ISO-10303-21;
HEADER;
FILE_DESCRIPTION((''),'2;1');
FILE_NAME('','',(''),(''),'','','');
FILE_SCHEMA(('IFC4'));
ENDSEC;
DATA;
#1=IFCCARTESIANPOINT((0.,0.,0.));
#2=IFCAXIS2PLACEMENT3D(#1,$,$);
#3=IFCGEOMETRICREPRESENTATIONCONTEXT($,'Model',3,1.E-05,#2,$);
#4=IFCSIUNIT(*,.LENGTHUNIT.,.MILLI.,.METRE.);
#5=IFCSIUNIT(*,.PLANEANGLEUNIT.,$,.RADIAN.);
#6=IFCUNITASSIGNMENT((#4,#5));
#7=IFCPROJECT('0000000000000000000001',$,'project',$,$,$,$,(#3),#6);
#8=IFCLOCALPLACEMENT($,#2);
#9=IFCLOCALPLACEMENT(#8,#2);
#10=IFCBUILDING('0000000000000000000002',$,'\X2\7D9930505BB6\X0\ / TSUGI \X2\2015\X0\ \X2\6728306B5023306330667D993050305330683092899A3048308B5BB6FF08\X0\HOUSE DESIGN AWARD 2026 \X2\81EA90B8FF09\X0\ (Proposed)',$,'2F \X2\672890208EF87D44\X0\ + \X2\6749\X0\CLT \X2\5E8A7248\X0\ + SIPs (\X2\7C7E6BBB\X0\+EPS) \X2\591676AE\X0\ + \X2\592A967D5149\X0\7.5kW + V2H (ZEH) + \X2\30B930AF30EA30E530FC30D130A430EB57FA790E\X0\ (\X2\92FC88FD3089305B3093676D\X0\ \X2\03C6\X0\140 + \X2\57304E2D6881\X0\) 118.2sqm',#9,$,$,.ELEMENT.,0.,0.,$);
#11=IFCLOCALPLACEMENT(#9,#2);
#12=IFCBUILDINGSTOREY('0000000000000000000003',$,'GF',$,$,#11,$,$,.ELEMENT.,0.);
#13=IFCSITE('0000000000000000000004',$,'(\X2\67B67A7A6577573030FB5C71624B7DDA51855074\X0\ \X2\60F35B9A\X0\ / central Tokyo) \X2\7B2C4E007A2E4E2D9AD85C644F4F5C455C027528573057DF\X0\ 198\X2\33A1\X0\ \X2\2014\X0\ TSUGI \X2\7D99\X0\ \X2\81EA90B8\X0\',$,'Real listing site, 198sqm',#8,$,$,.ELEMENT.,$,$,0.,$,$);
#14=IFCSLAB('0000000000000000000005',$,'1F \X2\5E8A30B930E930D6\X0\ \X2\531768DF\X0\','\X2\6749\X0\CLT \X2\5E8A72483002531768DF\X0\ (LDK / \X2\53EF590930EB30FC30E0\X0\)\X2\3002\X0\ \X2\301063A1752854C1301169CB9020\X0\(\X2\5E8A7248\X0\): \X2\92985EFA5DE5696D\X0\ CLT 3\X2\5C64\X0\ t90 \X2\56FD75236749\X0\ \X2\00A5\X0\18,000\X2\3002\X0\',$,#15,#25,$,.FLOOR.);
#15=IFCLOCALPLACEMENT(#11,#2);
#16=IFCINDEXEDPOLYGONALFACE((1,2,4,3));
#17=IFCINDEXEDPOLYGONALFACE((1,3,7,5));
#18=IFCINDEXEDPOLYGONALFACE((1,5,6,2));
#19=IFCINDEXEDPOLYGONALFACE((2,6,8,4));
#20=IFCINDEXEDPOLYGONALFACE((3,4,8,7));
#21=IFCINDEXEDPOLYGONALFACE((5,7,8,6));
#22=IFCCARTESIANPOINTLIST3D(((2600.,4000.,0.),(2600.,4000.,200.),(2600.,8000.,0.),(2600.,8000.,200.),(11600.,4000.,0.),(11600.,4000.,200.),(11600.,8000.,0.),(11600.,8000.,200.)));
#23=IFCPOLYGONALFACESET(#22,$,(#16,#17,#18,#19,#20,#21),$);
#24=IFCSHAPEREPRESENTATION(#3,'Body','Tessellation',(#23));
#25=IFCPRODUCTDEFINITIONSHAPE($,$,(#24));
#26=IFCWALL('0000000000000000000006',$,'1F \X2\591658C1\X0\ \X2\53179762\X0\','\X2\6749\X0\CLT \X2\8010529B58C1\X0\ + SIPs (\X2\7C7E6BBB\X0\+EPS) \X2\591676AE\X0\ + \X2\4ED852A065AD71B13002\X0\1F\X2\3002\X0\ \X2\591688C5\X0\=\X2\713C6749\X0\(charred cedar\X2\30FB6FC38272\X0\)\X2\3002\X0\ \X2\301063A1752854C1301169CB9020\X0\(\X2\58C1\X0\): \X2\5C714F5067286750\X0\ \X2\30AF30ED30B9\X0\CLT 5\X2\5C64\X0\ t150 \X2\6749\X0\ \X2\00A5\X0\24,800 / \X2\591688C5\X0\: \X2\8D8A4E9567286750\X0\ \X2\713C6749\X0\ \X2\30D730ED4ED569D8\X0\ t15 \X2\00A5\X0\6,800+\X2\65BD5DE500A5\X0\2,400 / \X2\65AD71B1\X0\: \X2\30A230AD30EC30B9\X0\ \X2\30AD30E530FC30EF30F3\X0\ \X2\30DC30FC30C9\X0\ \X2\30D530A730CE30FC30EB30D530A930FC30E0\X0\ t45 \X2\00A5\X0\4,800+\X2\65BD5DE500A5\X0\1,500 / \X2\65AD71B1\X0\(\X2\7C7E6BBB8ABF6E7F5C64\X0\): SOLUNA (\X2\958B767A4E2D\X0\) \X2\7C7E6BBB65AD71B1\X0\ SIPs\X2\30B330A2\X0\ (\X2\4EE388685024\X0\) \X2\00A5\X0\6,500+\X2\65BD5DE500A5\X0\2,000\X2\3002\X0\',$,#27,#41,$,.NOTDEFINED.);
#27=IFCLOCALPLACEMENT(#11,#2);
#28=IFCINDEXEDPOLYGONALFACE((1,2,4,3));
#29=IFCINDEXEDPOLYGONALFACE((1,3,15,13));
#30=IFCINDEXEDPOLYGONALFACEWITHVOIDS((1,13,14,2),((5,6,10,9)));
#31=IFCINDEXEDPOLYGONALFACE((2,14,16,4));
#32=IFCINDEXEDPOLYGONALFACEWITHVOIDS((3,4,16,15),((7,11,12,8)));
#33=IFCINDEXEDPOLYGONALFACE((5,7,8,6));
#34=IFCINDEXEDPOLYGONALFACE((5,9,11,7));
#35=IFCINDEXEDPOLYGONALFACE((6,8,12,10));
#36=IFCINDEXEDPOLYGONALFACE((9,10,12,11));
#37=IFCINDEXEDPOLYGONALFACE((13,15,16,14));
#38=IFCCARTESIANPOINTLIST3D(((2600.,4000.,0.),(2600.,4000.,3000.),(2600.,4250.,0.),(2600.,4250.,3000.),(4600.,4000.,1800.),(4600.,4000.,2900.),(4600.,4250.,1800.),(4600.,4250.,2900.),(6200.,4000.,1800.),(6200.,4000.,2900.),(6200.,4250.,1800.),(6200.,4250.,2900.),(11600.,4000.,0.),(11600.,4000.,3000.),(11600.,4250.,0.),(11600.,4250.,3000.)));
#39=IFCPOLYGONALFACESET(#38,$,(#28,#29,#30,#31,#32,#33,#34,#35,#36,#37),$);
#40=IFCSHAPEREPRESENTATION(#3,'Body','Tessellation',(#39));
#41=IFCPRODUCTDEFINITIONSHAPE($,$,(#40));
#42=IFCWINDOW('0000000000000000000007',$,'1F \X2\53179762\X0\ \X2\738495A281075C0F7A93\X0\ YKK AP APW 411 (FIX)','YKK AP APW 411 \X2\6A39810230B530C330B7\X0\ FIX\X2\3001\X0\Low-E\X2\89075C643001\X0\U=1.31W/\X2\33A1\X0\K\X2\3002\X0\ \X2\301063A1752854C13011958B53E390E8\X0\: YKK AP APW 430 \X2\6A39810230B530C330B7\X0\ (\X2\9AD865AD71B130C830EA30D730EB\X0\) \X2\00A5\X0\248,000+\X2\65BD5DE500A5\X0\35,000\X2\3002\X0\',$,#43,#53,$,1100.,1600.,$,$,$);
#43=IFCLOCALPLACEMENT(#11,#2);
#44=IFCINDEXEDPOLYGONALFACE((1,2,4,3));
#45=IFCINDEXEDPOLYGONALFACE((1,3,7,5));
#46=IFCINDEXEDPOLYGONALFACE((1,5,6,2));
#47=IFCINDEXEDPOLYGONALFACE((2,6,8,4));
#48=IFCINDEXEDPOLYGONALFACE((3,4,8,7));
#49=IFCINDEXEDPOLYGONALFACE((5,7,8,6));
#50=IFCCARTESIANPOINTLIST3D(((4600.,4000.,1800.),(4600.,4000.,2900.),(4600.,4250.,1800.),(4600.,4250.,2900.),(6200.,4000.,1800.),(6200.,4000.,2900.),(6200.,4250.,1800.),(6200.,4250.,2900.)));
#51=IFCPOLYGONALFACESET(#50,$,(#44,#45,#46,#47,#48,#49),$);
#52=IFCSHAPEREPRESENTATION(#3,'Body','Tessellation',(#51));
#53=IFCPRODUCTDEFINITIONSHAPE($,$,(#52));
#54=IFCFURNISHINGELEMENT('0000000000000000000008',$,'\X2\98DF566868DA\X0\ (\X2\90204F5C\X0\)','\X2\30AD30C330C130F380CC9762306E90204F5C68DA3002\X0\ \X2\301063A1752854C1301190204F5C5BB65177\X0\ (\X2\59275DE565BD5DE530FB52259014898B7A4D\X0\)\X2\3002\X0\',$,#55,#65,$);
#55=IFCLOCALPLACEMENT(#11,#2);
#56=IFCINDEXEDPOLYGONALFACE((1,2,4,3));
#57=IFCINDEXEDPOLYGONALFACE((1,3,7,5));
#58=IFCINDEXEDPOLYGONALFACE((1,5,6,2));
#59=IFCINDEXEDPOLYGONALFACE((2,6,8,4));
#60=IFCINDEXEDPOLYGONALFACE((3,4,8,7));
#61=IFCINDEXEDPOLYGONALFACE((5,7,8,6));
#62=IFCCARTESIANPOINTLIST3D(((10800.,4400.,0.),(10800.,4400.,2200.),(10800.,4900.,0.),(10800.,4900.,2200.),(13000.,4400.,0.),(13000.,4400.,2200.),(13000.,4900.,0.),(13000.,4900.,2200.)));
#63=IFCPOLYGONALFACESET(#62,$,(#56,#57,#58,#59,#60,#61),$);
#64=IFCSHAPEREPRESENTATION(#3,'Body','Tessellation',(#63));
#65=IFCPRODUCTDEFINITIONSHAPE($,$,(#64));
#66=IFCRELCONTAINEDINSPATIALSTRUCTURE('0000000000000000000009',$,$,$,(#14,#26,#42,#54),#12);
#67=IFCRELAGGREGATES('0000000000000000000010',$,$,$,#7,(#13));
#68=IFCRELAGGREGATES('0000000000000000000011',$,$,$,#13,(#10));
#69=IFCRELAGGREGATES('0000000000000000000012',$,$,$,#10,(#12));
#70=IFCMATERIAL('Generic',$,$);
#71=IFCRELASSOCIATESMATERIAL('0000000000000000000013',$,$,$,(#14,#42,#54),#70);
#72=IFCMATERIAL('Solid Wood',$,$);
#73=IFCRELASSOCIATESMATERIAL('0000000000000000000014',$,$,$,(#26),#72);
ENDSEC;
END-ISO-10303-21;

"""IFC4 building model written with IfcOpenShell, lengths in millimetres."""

from ifc_helpers import new_model, si_unit, frame, frame_2d, origin, place, context, project, spatial, rectangle, extrude, material, element, fill, save


model = new_model("IFC4")

# Units and contexts
model_context = context("Model", 3, precision=1e-05, world=origin())
ifc_project = project(units=[si_unit("LENGTHUNIT", "METRE", prefix="MILLI"), si_unit("PLANEANGLEUNIT", "RADIAN")], contexts=[model_context])

# Site, building, storey
site_placement = place(None, origin())
site = spatial("IfcSite", under=ifc_project, at=site_placement, Name="(架空敷地・山手線内側 想定 / central Tokyo) 第一種中高層住居専用地域 198㎡ — TSUGI 継 自邸", ObjectType="Real listing site, 198sqm", CompositionType="ELEMENT", RefElevation=0.0)
building_placement = place(site_placement, origin())
building = spatial("IfcBuilding", under=site, at=building_placement, Name="継ぐ家 / TSUGI ― 木に倣って継ぐことを覚える家（HOUSE DESIGN AWARD 2026 自邸） (Proposed)", ObjectType="2F 木造軸組 + 杉CLT 床版 + SIPs (籾殻+EPS) 外皮 + 太陽光7.5kW + V2H (ZEH) + スクリューパイル基礎 (鋼製らせん杭 φ140 + 地中梁) 118.2sqm", CompositionType="ELEMENT", ElevationOfRefHeight=0.0, ElevationOfTerrain=0.0)
storey_placement = place(building_placement, origin())
storey = spatial("IfcBuildingStorey", under=building, at=storey_placement, Name="GF", CompositionType="ELEMENT", Elevation=0.0)

# Shared definitions
ifc_material_1 = material(Name="Generic")

# Slab
slab_1_placement = place(storey_placement, frame((1300.0, 2000.0, 0.0)))
element("IfcSlab", 1, at=slab_1_placement, inside=storey, material=ifc_material_1, Name="1F 床スラブ 北棟", Description="杉CLT 床版。北棟 (LDK / 可変ルーム)。 【採用品】構造(床版): 銘建工業 CLT 3層 t90 国産杉 ¥18,000。", PredefinedType="FLOOR", context=model_context, shape_type="SweptSolid", body=[
    extrude(rectangle(XDim=9000.0, YDim=4000.0, at=frame_2d((4500.0, 2000.0))), frame((1300.0, 2000.0, 0.0)), (0.0, 0.0, 1.0), 200.0),
])

# Wall, opening, window
ifc_material_2 = material(Name="Solid Wood")
wall_1_placement = place(storey_placement, frame((1300.0, 2000.0, 0.0)))
wall_1 = element("IfcWall", 2, at=wall_1_placement, inside=storey, material=ifc_material_2, Name="1F 外壁 北面", Description="杉CLT 耐力壁 + SIPs (籾殻+EPS) 外皮 + 付加断熱。1F。 外装=焼杉(charred cedar・濃色)。 【採用品】構造(壁): 山佐木材 クロスCLT 5層 t150 杉 ¥24,800 / 外装: 越井木材 焼杉 プロ仕様 t15 ¥6,800+施工¥2,400 / 断熱: アキレス キューワン ボード フェノールフォーム t45 ¥4,800+施工¥1,500 / 断熱(籾殻調湿層): SOLUNA (開発中) 籾殻断熱 SIPsコア (代表値) ¥6,500+施工¥2,000。", PredefinedType="NOTDEFINED", context=model_context, shape_type="SweptSolid", body=[
    extrude(rectangle(XDim=9000.0, YDim=250.0, at=frame_2d((4500.0, 125.0))), frame((1300.0, 2000.0, 0.0)), (0.0, 0.0, 1.0), 3000.0),
])
opening_placement = place(storey_placement, frame((2300.0, 2000.0, 900.0)))
opening = element("IfcOpeningElement", 3, at=opening_placement, cuts=wall_1, PredefinedType="NOTDEFINED", context=model_context, shape_type="SweptSolid", body=[
    extrude(rectangle(XDim=1600.0, YDim=250.0, at=frame_2d((800.0, 125.0))), frame((2300.0, 2000.0, 900.0)), (0.0, 0.0, 1.0), 1100.0),
])
window_placement = place(storey_placement, frame((2300.0, 2000.0, 900.0)))
window = element("IfcWindow", 4, at=window_placement, inside=storey, material=ifc_material_1, Name="1F 北面 玄関脇小窓 YKK AP APW 411 (FIX)", Description="YKK AP APW 411 樹脂サッシ FIX、Low-E複層、U=1.31W/㎡K。 【採用品】開口部: YKK AP APW 430 樹脂サッシ (高断熱トリプル) ¥248,000+施工¥35,000。", OverallHeight=1100.0, OverallWidth=1600.0, context=model_context, shape_type="SweptSolid", body=[
    extrude(rectangle(XDim=1600.0, YDim=250.0, at=frame_2d((800.0, 125.0))), frame((2300.0, 2000.0, 900.0)), (0.0, 0.0, 1.0), 1100.0),
])
fill(opening, window)

# Furnishing element
furnishing_1_placement = place(storey_placement, frame((5400.0, 2200.0, 0.0)))
element("IfcFurnishingElement", 5, at=furnishing_1_placement, inside=storey, material=ifc_material_1, Name="食器棚 (造作)", Description="キッチン背面の造作棚。 【採用品】造作家具 (大工施工・別途見積)。", context=model_context, shape_type="SweptSolid", body=[
    extrude(rectangle(XDim=2200.0, YDim=500.0, at=frame_2d((1100.0, 250.0))), frame((5400.0, 2200.0, 0.0)), (0.0, 0.0, 1.0), 2200.0),
])

save(model, "model.ifc")
